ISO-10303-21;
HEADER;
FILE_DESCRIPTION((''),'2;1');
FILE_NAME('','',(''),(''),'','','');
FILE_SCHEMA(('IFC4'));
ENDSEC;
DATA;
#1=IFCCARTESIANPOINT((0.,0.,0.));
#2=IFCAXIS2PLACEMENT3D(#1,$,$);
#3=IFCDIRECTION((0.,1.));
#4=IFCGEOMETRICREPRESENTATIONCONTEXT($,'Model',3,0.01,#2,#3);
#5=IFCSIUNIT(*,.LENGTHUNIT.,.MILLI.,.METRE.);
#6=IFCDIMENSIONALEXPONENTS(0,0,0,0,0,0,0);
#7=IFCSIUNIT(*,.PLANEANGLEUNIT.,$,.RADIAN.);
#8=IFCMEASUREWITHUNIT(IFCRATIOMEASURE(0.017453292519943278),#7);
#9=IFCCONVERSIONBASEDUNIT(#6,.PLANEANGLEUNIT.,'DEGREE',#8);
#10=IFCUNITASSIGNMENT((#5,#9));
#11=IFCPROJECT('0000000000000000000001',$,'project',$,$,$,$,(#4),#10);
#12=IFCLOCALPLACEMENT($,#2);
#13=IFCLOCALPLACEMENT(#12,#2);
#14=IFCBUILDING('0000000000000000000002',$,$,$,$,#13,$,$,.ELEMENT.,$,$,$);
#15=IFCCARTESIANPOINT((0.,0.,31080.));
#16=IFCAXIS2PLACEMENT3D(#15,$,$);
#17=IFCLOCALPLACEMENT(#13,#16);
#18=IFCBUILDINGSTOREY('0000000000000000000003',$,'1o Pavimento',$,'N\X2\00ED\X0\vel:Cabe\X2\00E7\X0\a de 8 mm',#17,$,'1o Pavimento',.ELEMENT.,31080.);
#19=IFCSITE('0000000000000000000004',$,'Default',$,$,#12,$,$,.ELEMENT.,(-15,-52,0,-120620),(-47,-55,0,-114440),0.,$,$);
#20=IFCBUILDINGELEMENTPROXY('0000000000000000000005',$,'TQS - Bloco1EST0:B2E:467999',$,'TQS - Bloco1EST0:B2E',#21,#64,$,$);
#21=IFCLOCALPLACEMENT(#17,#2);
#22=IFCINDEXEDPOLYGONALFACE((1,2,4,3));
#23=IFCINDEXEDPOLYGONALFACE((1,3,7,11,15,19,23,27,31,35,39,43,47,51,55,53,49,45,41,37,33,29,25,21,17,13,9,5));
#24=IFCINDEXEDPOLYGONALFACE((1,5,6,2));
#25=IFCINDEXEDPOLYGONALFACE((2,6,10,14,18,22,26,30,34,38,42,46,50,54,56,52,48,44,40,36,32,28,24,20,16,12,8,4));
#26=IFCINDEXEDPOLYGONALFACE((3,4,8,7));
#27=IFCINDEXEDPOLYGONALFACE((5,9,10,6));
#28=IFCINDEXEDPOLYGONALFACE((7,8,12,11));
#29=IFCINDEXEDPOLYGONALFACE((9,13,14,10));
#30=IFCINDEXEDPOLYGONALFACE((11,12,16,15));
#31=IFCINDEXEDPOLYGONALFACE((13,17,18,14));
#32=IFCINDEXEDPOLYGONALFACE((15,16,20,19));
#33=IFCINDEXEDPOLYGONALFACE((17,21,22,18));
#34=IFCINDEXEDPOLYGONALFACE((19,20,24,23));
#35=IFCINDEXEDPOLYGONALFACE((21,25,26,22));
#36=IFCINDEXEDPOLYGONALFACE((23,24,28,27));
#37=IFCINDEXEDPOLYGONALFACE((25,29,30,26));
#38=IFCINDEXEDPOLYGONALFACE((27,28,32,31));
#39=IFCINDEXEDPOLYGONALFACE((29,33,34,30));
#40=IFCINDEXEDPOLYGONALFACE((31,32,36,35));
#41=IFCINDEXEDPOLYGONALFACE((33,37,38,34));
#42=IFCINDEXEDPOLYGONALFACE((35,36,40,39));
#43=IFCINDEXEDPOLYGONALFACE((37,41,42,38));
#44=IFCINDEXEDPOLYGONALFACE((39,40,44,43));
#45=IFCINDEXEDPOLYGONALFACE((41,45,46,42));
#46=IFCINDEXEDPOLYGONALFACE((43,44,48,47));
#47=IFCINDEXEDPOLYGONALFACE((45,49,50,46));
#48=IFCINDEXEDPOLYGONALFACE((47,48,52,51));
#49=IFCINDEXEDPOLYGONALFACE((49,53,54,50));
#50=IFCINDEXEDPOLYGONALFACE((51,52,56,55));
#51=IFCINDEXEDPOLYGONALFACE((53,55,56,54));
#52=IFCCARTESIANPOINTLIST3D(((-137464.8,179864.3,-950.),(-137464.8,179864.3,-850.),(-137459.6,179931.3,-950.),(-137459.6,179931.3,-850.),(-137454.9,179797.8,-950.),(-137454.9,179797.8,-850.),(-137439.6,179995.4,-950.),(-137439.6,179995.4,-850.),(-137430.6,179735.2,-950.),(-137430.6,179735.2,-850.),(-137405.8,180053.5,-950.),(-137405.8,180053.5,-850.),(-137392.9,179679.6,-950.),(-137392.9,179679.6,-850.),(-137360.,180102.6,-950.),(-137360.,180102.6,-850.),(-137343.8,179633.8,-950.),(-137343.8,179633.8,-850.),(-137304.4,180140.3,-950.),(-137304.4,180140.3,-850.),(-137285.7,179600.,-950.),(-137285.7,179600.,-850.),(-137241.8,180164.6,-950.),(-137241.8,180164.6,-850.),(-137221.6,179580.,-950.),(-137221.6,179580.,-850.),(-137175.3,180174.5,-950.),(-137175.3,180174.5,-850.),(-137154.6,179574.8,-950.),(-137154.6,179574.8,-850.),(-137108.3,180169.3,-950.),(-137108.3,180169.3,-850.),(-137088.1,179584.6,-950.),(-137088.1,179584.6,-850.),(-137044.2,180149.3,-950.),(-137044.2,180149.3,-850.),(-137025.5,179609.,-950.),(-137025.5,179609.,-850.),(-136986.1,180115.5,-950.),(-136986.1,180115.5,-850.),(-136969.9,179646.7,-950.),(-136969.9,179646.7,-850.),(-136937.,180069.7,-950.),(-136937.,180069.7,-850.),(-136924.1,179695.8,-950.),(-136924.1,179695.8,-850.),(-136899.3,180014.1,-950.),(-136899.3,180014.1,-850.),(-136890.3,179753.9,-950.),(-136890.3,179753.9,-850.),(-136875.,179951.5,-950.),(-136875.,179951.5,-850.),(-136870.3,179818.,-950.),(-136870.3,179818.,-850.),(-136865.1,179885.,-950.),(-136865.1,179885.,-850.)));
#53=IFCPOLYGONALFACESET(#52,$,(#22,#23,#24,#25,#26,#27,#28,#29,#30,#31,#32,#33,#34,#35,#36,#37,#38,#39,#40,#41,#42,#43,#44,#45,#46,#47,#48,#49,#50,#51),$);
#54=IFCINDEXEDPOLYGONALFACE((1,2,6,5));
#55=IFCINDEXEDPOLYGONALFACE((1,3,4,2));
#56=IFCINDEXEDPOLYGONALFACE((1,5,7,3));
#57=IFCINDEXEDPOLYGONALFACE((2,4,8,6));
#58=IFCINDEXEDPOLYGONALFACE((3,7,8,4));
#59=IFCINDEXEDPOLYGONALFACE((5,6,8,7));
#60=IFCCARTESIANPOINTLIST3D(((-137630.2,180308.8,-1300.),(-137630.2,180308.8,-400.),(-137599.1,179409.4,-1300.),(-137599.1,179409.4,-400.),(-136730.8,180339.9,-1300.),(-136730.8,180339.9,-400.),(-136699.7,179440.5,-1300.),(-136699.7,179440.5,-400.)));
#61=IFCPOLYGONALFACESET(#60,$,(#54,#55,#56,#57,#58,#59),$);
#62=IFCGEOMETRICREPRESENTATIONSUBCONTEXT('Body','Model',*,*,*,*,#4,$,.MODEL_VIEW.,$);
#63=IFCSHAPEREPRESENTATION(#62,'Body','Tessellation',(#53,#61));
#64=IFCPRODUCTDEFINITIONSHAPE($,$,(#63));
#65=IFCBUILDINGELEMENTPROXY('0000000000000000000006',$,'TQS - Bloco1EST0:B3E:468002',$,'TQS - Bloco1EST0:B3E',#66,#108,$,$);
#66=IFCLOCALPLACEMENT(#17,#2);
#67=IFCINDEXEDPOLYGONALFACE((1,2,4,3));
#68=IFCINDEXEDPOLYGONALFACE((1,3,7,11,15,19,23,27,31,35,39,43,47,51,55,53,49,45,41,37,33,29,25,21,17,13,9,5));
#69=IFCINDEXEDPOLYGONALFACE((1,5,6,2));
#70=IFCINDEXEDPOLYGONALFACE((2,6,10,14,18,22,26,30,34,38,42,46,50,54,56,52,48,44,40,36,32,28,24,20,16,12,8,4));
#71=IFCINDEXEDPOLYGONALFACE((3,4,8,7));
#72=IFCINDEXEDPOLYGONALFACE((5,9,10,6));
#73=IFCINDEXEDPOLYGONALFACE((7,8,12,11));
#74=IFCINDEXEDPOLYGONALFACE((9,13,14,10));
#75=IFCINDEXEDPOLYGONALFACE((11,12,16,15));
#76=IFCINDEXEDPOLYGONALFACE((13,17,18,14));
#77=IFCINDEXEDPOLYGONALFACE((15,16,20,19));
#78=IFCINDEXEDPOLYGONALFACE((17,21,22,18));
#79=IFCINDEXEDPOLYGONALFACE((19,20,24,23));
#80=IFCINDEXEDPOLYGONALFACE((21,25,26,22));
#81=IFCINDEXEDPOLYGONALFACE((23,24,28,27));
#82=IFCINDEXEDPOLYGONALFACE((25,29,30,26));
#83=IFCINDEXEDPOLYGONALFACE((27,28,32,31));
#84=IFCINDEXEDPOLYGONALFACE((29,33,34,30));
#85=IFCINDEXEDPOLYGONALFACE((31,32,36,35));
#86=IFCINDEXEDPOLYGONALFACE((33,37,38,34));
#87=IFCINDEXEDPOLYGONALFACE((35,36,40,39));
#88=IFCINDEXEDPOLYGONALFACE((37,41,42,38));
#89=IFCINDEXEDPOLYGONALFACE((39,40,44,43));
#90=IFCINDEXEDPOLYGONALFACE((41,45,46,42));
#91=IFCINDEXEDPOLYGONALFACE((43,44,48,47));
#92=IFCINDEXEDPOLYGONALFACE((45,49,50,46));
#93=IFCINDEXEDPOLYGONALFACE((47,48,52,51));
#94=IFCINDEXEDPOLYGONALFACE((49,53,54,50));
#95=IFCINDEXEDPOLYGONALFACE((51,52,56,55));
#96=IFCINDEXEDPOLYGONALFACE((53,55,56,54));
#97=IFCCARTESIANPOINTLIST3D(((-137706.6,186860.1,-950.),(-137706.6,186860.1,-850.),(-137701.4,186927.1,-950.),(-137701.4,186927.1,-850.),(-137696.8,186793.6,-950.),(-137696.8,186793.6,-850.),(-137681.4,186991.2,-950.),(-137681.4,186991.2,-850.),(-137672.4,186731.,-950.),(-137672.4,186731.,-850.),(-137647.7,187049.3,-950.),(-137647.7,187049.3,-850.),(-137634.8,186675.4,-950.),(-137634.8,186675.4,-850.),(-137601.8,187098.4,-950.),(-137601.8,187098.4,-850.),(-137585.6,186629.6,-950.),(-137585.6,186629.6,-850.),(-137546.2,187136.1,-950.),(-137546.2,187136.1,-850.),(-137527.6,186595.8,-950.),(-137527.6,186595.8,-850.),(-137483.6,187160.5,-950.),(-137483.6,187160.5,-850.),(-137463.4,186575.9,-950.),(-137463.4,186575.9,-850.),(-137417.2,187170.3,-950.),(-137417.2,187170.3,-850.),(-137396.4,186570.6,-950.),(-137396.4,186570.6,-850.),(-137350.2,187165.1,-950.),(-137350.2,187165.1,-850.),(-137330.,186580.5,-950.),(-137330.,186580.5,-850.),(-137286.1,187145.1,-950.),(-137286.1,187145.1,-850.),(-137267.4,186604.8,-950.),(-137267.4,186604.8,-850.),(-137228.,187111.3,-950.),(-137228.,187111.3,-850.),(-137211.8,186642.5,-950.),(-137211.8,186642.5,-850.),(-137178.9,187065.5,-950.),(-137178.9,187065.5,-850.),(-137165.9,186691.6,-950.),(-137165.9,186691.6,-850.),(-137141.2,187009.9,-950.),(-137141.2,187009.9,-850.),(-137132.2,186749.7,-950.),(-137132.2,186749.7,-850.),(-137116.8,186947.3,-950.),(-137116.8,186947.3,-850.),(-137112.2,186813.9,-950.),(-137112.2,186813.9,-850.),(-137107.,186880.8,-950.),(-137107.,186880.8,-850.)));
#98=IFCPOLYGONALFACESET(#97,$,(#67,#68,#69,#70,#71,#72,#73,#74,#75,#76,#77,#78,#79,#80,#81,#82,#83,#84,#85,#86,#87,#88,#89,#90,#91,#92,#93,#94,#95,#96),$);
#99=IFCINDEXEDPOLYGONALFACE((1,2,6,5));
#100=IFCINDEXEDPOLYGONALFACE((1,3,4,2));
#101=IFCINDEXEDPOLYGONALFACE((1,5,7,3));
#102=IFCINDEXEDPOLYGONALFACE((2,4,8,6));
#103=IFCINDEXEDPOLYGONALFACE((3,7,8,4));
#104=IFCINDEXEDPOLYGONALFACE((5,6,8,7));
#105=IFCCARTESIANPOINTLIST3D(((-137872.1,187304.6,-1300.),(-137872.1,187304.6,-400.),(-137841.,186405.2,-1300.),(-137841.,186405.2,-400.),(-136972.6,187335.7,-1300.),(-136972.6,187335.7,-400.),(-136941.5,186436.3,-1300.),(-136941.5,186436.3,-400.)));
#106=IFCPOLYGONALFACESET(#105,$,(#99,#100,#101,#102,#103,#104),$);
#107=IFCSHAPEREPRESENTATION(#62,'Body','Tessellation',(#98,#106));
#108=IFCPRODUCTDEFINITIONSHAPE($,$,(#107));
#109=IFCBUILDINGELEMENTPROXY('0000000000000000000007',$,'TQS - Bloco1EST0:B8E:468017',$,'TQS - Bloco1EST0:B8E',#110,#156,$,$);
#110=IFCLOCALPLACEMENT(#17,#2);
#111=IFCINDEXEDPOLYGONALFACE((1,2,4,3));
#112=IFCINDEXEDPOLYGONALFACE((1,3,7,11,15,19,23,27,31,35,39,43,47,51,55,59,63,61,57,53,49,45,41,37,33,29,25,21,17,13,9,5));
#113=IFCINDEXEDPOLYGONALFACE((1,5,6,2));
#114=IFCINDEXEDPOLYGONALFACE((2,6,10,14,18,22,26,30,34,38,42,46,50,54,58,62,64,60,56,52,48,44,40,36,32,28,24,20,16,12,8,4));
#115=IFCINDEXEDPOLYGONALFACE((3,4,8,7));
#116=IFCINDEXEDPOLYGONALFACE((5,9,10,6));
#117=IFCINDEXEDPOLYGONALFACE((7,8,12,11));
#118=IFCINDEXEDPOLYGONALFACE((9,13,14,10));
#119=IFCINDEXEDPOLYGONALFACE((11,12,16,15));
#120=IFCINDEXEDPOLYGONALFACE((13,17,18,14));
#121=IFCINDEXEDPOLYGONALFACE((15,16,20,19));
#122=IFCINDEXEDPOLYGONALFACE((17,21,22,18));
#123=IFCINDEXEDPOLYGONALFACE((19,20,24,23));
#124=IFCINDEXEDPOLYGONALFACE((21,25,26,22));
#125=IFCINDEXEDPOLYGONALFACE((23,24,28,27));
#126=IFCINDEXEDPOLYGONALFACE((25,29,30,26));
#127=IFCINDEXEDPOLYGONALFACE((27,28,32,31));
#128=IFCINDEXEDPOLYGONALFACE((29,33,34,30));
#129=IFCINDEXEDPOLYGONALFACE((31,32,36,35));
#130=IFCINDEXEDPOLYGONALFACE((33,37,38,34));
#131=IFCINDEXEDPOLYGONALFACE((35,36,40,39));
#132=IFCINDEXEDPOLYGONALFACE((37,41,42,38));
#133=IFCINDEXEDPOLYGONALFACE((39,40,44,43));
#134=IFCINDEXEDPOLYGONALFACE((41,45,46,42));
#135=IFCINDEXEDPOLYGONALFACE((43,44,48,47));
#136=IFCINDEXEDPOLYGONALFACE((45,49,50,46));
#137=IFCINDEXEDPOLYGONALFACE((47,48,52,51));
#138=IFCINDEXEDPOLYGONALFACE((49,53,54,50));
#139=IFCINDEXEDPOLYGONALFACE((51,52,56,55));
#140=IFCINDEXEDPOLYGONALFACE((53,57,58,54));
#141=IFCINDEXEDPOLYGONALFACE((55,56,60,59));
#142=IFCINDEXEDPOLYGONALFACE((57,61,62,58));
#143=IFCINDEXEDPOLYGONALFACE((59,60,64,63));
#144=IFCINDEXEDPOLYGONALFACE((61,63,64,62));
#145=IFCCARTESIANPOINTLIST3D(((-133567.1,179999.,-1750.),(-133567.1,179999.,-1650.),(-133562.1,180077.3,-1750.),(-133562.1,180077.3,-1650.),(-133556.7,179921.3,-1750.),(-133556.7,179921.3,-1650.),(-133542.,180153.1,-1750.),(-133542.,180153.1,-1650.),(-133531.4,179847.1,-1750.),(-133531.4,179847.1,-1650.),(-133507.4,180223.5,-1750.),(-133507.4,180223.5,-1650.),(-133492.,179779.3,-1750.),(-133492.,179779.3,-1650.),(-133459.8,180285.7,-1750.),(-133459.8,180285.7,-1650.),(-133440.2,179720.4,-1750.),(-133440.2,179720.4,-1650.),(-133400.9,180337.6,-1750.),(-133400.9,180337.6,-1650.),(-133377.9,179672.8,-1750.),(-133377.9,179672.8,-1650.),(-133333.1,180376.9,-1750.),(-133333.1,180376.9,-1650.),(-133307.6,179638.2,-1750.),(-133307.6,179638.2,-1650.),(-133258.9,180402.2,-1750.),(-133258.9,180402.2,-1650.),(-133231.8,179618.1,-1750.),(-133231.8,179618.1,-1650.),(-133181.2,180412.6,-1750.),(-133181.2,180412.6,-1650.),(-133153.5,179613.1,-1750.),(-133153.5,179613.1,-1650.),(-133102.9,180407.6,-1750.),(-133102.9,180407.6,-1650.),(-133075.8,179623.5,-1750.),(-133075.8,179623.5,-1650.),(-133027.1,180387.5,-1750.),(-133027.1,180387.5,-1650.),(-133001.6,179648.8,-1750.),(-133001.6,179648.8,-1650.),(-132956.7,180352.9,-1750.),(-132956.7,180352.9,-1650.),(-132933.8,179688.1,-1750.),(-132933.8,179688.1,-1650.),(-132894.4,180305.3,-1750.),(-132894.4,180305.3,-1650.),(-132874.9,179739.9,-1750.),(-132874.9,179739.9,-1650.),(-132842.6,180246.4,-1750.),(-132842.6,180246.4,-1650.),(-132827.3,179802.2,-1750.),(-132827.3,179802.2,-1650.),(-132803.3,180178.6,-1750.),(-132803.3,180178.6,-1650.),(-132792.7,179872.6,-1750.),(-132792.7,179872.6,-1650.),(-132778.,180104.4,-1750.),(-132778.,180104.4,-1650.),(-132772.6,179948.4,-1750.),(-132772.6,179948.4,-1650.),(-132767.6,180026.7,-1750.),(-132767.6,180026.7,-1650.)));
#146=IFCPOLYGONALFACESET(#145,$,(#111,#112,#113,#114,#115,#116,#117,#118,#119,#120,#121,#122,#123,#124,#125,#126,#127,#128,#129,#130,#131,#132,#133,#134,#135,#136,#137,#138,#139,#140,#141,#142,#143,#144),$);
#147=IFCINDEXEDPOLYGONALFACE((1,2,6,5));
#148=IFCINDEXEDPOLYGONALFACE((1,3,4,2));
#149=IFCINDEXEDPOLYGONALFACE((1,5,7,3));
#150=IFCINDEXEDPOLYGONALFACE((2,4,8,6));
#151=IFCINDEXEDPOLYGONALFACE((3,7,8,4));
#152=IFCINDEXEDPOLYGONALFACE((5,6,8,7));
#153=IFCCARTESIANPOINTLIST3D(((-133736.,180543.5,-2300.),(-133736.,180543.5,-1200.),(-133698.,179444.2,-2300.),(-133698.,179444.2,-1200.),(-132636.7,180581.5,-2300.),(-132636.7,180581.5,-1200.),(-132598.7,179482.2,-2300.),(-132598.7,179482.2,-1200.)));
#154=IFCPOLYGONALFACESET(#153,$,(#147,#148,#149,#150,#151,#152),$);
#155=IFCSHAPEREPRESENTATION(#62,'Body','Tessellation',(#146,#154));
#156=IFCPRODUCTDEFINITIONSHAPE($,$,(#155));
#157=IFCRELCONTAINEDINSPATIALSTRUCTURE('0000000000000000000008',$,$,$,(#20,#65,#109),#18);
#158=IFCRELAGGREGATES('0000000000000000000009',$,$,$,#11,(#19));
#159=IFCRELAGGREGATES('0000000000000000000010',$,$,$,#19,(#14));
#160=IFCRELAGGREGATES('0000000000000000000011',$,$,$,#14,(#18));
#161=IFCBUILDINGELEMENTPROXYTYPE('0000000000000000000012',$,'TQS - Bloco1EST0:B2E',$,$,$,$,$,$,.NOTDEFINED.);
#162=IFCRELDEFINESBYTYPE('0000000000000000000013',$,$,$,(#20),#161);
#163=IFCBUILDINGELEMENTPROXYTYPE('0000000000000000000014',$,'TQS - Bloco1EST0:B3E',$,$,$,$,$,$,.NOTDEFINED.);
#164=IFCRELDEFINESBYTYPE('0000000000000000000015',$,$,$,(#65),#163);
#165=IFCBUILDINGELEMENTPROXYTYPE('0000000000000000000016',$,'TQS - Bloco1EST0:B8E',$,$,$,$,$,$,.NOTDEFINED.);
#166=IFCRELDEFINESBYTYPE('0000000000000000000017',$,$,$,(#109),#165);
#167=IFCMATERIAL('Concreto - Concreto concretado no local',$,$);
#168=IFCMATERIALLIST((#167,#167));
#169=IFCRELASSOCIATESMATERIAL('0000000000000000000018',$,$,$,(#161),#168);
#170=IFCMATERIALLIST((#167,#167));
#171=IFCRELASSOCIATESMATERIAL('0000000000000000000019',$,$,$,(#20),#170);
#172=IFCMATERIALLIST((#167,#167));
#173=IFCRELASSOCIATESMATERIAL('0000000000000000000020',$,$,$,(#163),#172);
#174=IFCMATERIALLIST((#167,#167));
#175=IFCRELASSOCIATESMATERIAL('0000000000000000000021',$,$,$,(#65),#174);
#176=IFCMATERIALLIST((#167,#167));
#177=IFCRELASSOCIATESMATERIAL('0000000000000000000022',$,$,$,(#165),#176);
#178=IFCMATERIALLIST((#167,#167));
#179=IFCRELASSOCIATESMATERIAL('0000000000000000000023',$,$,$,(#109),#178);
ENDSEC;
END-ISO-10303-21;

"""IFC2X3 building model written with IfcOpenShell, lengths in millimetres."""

from ifc_helpers import new_model, entity, si_unit, converted_unit, direction, frame, frame_2d, origin, origin_2d_with_axis, place, context, subcontext, project, spatial, rectangle, circle, extrude, source, transform, mapped, material, material_list, type_object, type_shapes, element, save


model = new_model("IFC2X3")

# Units and contexts
model_context = context("Model", 3, precision=0.01, world=origin(), true_north=direction((0.0, 1.0)))
body_context = subcontext(model_context, "Body", "Model", "MODEL_VIEW")
ifc_project = project(units=[si_unit("LENGTHUNIT", "METRE", prefix="MILLI"), converted_unit("PLANEANGLEUNIT", "DEGREE", entity("IfcRatioMeasure", 0.017453292519943278), si_unit("PLANEANGLEUNIT", "RADIAN"), dimensions=[0, 0, 0, 0, 0, 0, 0])], contexts=[model_context])

# Site, building, storey
site_placement = place(None, origin())
site = spatial("IfcSite", under=ifc_project, at=site_placement, Name="Default", CompositionType="ELEMENT", RefLatitude=(-15, -52, 0, -120620), RefLongitude=(-47, -55, 0, -114440), RefElevation=0.0)
building_placement = place(site_placement, origin())
building = spatial("IfcBuilding", under=site, at=building_placement, CompositionType="ELEMENT")
storey_placement = place(building_placement, frame((0.0, 0.0, 31080.0)))
storey = spatial("IfcBuildingStorey", under=building, at=storey_placement, Name="1o Pavimento", ObjectType="Nível:Cabeça de 8 mm", LongName="1o Pavimento", CompositionType="ELEMENT", Elevation=31080.0)

# Building element proxies
ifc_material_1 = material(Name="Concreto - Concreto concretado no local")
ifc_material_list_1 = material_list([ifc_material_1, ifc_material_1])
ifc_material_list_2 = material_list([ifc_material_1, ifc_material_1])
building_element_proxy_type_1 = type_object("IfcBuildingElementProxyType", Name="TQS - Bloco1EST0:B2E", PredefinedType="NOTDEFINED", material=ifc_material_list_2)
shared_shape_1 = source(origin(), body_context, "Body", "SweptSolid", [
    extrude(circle(Radius=300.0, at=frame_2d((0.0, 0.0), x_axis=(1.0, 0.0))), frame((0.0, 0.0, -550.0)), (0.0, 0.0, 1.0), 100.0),
    extrude(rectangle(XDim=900.0, YDim=900.0, at=origin_2d_with_axis()), frame((0.0, 0.0, -900.0), z_axis=(0.0, 0.0, 1.0), x_axis=(-1.0, 0.0, 0.0)), (0.0, 0.0, 1.0), 900.0),
])
type_shapes(building_element_proxy_type_1, [shared_shape_1])
proxy_1_placement = place(storey_placement, frame((-137165.0, 179874.6, -400.0), z_axis=(0.0, 0.0, 1.0), x_axis=(-0.034551, 0.999403, 0.0)))
element("IfcBuildingElementProxy", 1, at=proxy_1_placement, inside=storey, type_object=building_element_proxy_type_1, material=ifc_material_list_1, Name="TQS - Bloco1EST0:B2E:467999", ObjectType="TQS - Bloco1EST0:B2E", context=body_context, shape_type="MappedRepresentation", body=[
    mapped(shared_shape_1, transform((0.0, 0.0, 0.0), scale=1.0)),
])
ifc_material_list_3 = material_list([ifc_material_1, ifc_material_1])
ifc_material_list_4 = material_list([ifc_material_1, ifc_material_1])
building_element_proxy_type_2 = type_object("IfcBuildingElementProxyType", Name="TQS - Bloco1EST0:B3E", PredefinedType="NOTDEFINED", material=ifc_material_list_4)
shared_shape_2 = source(origin(), body_context, "Body", "SweptSolid", [
    extrude(circle(Radius=300.0, at=frame_2d((0.0, 0.0), x_axis=(1.0, 0.0))), frame((0.0, 0.0, -550.0)), (0.0, 0.0, 1.0), 100.0),
    extrude(rectangle(XDim=900.0, YDim=900.0, at=origin_2d_with_axis()), frame((0.0, 0.0, -900.0), z_axis=(0.0, 0.0, 1.0), x_axis=(-1.0, 0.0, 0.0)), (0.0, 0.0, 1.0), 900.0),
])
type_shapes(building_element_proxy_type_2, [shared_shape_2])
proxy_2_placement = place(storey_placement, frame((-137406.8, 186870.5, -400.0), z_axis=(0.0, 0.0, 1.0), x_axis=(-0.034551, 0.999403, 0.0)))
element("IfcBuildingElementProxy", 2, at=proxy_2_placement, inside=storey, type_object=building_element_proxy_type_2, material=ifc_material_list_3, Name="TQS - Bloco1EST0:B3E:468002", ObjectType="TQS - Bloco1EST0:B3E", context=body_context, shape_type="MappedRepresentation", body=[
    mapped(shared_shape_2, transform((0.0, 0.0, 0.0), scale=1.0)),
])
ifc_material_list_5 = material_list([ifc_material_1, ifc_material_1])
ifc_material_list_6 = material_list([ifc_material_1, ifc_material_1])
building_element_proxy_type_3 = type_object("IfcBuildingElementProxyType", Name="TQS - Bloco1EST0:B8E", PredefinedType="NOTDEFINED", material=ifc_material_list_6)
shared_shape_3 = source(origin(), body_context, "Body", "SweptSolid", [
    extrude(circle(Radius=400.0, at=frame_2d((0.0, 0.0), x_axis=(1.0, 0.0))), frame((0.0, 0.0, -550.0)), (0.0, 0.0, 1.0), 100.0),
    extrude(rectangle(XDim=1100.0, YDim=1100.0, at=origin_2d_with_axis()), frame((0.0, 0.0, -1100.0), z_axis=(0.0, 0.0, 1.0), x_axis=(-1.0, 0.0, 0.0)), (0.0, 0.0, 1.0), 1100.0),
])
type_shapes(building_element_proxy_type_3, [shared_shape_3])
proxy_3_placement = place(storey_placement, frame((-133167.3, 180012.8, -1200.0), z_axis=(0.0, 0.0, 1.0), x_axis=(-0.034551, 0.999403, 0.0)))
element("IfcBuildingElementProxy", 3, at=proxy_3_placement, inside=storey, type_object=building_element_proxy_type_3, material=ifc_material_list_5, Name="TQS - Bloco1EST0:B8E:468017", ObjectType="TQS - Bloco1EST0:B8E", context=body_context, shape_type="MappedRepresentation", body=[
    mapped(shared_shape_3, transform((0.0, 0.0, 0.0), scale=1.0)),
])

save(model, "model.ifc")
